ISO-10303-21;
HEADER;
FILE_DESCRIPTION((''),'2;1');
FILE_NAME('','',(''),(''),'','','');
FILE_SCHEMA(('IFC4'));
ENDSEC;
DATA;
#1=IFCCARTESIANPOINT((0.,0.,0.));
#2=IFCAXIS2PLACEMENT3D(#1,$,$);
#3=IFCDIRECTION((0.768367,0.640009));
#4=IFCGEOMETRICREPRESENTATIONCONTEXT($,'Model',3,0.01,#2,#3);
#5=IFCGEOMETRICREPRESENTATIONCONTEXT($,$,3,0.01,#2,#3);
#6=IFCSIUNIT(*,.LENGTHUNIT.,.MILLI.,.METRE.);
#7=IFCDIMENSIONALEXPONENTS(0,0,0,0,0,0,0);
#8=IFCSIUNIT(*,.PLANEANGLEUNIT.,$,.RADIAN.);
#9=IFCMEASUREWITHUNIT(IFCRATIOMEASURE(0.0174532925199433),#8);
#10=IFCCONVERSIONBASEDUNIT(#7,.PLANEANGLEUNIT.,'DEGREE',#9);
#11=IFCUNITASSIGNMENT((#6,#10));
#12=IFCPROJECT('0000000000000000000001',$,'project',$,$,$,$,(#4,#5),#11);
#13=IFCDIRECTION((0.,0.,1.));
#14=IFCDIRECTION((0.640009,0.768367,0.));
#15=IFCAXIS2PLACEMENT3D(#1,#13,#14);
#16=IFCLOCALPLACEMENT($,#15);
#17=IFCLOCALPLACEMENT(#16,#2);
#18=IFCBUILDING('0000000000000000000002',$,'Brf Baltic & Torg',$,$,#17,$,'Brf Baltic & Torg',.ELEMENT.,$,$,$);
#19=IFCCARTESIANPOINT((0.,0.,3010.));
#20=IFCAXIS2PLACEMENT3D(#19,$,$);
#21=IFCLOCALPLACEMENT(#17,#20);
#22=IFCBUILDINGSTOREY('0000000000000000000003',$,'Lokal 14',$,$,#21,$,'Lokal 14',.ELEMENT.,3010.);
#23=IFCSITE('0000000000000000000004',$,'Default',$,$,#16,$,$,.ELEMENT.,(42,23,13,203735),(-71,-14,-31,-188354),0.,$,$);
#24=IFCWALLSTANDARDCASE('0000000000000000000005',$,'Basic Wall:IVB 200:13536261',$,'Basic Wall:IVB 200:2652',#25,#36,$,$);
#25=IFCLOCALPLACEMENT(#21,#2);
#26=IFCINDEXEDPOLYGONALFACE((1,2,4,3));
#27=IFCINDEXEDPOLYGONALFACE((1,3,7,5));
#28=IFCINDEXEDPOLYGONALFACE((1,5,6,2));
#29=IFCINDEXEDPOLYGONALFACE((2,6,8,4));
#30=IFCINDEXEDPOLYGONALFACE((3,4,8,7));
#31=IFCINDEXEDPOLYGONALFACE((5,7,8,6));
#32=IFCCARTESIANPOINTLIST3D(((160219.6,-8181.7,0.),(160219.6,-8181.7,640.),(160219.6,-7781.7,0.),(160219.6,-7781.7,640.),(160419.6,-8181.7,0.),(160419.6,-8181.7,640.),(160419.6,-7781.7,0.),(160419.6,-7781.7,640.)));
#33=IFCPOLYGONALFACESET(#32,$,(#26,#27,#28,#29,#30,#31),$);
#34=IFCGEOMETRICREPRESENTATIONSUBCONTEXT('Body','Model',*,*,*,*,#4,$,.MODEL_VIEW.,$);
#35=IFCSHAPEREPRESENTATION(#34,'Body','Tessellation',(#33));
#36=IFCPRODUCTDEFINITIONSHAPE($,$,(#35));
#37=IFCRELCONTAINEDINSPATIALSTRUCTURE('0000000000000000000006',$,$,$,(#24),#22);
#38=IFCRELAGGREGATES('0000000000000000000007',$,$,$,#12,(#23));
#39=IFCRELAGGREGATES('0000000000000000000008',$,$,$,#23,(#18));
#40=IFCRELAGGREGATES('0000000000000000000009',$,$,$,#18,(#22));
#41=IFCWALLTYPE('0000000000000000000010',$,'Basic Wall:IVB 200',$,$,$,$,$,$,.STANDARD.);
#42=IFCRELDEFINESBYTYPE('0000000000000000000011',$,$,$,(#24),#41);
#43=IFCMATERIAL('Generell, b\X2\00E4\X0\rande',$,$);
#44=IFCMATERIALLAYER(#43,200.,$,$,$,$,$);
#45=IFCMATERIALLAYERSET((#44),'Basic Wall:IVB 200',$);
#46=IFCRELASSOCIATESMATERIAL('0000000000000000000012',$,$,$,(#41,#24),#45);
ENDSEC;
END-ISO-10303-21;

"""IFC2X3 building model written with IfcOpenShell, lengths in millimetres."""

from ifc_helpers import new_model, entity, si_unit, converted_unit, direction, frame, frame_2d, origin, place, context, subcontext, project, spatial, rectangle, extrude, clip, halfspace, material, layer, layer_set, layer_usage, type_object, element, save


model = new_model("IFC2X3")

# Units and contexts
model_context = context("Model", 3, precision=0.01, world=origin(), true_north=direction((0.768367, 0.640009)))
context_of_model = context(None, 3, precision=0.01, world=origin(), true_north=direction((0.768367, 0.640009)))
body_context = subcontext(model_context, "Body", "Model", "MODEL_VIEW")
ifc_project = project(units=[si_unit("LENGTHUNIT", "METRE", prefix="MILLI"), converted_unit("PLANEANGLEUNIT", "DEGREE", entity("IfcRatioMeasure", 0.0174532925199433), si_unit("PLANEANGLEUNIT", "RADIAN"), dimensions=[0, 0, 0, 0, 0, 0, 0])], contexts=[model_context, context_of_model])

# Site, building, storey
site_placement = place(None, frame((0.0, 0.0, 0.0), z_axis=(0.0, 0.0, 1.0), x_axis=(0.640009, 0.768367, 0.0)))
site = spatial("IfcSite", under=ifc_project, at=site_placement, Name="Default", CompositionType="ELEMENT", RefLatitude=(42, 23, 13, 203735), RefLongitude=(-71, -14, -31, -188354), RefElevation=0.0)
building_placement = place(site_placement, origin())
building = spatial("IfcBuilding", under=site, at=building_placement, Name="Brf Baltic & Torg", LongName="Brf Baltic & Torg", CompositionType="ELEMENT")
storey_placement = place(building_placement, frame((0.0, 0.0, 3010.0)))
storey = spatial("IfcBuildingStorey", under=building, at=storey_placement, Name="Lokal 14", LongName="Lokal 14", CompositionType="ELEMENT", Elevation=3010.0)

# Shared definitions
ifc_material_1 = material(Name="Generell, bärande")
ifc_layer = layer(ifc_material_1, 200.0)
ifc_layer_set = layer_set([ifc_layer], Name="Basic Wall:IVB 200")
wall_type = type_object("IfcWallType", Name="Basic Wall:IVB 200", PredefinedType="STANDARD", material=ifc_layer_set)

# Wall
ifc_layer_usage_1 = layer_usage(ifc_layer_set, "AXIS2", "NEGATIVE", 100.0)
wall_1_placement = place(storey_placement, frame((160319.6, -8181.7, 0.0), z_axis=(0.0, 0.0, 1.0), x_axis=(0.0, 1.0, 0.0)))
element("IfcWallStandardCase", 1, at=wall_1_placement, inside=storey, type_object=wall_type, material=ifc_layer_usage_1, Name="Basic Wall:IVB 200:13536261", ObjectType="Basic Wall:IVB 200:2652", context=body_context, shape_type="Clipping", body=[
    clip(extrude(rectangle(XDim=400.0, YDim=200.0, at=frame_2d((200.0, 0.0), x_axis=(-1.0, 0.0))), origin(), (0.0, 0.0, 1.0), 640.0), halfspace(frame((0.0, 0.0, -1360.0)), True)),
])

save(model, "model.ifc")
